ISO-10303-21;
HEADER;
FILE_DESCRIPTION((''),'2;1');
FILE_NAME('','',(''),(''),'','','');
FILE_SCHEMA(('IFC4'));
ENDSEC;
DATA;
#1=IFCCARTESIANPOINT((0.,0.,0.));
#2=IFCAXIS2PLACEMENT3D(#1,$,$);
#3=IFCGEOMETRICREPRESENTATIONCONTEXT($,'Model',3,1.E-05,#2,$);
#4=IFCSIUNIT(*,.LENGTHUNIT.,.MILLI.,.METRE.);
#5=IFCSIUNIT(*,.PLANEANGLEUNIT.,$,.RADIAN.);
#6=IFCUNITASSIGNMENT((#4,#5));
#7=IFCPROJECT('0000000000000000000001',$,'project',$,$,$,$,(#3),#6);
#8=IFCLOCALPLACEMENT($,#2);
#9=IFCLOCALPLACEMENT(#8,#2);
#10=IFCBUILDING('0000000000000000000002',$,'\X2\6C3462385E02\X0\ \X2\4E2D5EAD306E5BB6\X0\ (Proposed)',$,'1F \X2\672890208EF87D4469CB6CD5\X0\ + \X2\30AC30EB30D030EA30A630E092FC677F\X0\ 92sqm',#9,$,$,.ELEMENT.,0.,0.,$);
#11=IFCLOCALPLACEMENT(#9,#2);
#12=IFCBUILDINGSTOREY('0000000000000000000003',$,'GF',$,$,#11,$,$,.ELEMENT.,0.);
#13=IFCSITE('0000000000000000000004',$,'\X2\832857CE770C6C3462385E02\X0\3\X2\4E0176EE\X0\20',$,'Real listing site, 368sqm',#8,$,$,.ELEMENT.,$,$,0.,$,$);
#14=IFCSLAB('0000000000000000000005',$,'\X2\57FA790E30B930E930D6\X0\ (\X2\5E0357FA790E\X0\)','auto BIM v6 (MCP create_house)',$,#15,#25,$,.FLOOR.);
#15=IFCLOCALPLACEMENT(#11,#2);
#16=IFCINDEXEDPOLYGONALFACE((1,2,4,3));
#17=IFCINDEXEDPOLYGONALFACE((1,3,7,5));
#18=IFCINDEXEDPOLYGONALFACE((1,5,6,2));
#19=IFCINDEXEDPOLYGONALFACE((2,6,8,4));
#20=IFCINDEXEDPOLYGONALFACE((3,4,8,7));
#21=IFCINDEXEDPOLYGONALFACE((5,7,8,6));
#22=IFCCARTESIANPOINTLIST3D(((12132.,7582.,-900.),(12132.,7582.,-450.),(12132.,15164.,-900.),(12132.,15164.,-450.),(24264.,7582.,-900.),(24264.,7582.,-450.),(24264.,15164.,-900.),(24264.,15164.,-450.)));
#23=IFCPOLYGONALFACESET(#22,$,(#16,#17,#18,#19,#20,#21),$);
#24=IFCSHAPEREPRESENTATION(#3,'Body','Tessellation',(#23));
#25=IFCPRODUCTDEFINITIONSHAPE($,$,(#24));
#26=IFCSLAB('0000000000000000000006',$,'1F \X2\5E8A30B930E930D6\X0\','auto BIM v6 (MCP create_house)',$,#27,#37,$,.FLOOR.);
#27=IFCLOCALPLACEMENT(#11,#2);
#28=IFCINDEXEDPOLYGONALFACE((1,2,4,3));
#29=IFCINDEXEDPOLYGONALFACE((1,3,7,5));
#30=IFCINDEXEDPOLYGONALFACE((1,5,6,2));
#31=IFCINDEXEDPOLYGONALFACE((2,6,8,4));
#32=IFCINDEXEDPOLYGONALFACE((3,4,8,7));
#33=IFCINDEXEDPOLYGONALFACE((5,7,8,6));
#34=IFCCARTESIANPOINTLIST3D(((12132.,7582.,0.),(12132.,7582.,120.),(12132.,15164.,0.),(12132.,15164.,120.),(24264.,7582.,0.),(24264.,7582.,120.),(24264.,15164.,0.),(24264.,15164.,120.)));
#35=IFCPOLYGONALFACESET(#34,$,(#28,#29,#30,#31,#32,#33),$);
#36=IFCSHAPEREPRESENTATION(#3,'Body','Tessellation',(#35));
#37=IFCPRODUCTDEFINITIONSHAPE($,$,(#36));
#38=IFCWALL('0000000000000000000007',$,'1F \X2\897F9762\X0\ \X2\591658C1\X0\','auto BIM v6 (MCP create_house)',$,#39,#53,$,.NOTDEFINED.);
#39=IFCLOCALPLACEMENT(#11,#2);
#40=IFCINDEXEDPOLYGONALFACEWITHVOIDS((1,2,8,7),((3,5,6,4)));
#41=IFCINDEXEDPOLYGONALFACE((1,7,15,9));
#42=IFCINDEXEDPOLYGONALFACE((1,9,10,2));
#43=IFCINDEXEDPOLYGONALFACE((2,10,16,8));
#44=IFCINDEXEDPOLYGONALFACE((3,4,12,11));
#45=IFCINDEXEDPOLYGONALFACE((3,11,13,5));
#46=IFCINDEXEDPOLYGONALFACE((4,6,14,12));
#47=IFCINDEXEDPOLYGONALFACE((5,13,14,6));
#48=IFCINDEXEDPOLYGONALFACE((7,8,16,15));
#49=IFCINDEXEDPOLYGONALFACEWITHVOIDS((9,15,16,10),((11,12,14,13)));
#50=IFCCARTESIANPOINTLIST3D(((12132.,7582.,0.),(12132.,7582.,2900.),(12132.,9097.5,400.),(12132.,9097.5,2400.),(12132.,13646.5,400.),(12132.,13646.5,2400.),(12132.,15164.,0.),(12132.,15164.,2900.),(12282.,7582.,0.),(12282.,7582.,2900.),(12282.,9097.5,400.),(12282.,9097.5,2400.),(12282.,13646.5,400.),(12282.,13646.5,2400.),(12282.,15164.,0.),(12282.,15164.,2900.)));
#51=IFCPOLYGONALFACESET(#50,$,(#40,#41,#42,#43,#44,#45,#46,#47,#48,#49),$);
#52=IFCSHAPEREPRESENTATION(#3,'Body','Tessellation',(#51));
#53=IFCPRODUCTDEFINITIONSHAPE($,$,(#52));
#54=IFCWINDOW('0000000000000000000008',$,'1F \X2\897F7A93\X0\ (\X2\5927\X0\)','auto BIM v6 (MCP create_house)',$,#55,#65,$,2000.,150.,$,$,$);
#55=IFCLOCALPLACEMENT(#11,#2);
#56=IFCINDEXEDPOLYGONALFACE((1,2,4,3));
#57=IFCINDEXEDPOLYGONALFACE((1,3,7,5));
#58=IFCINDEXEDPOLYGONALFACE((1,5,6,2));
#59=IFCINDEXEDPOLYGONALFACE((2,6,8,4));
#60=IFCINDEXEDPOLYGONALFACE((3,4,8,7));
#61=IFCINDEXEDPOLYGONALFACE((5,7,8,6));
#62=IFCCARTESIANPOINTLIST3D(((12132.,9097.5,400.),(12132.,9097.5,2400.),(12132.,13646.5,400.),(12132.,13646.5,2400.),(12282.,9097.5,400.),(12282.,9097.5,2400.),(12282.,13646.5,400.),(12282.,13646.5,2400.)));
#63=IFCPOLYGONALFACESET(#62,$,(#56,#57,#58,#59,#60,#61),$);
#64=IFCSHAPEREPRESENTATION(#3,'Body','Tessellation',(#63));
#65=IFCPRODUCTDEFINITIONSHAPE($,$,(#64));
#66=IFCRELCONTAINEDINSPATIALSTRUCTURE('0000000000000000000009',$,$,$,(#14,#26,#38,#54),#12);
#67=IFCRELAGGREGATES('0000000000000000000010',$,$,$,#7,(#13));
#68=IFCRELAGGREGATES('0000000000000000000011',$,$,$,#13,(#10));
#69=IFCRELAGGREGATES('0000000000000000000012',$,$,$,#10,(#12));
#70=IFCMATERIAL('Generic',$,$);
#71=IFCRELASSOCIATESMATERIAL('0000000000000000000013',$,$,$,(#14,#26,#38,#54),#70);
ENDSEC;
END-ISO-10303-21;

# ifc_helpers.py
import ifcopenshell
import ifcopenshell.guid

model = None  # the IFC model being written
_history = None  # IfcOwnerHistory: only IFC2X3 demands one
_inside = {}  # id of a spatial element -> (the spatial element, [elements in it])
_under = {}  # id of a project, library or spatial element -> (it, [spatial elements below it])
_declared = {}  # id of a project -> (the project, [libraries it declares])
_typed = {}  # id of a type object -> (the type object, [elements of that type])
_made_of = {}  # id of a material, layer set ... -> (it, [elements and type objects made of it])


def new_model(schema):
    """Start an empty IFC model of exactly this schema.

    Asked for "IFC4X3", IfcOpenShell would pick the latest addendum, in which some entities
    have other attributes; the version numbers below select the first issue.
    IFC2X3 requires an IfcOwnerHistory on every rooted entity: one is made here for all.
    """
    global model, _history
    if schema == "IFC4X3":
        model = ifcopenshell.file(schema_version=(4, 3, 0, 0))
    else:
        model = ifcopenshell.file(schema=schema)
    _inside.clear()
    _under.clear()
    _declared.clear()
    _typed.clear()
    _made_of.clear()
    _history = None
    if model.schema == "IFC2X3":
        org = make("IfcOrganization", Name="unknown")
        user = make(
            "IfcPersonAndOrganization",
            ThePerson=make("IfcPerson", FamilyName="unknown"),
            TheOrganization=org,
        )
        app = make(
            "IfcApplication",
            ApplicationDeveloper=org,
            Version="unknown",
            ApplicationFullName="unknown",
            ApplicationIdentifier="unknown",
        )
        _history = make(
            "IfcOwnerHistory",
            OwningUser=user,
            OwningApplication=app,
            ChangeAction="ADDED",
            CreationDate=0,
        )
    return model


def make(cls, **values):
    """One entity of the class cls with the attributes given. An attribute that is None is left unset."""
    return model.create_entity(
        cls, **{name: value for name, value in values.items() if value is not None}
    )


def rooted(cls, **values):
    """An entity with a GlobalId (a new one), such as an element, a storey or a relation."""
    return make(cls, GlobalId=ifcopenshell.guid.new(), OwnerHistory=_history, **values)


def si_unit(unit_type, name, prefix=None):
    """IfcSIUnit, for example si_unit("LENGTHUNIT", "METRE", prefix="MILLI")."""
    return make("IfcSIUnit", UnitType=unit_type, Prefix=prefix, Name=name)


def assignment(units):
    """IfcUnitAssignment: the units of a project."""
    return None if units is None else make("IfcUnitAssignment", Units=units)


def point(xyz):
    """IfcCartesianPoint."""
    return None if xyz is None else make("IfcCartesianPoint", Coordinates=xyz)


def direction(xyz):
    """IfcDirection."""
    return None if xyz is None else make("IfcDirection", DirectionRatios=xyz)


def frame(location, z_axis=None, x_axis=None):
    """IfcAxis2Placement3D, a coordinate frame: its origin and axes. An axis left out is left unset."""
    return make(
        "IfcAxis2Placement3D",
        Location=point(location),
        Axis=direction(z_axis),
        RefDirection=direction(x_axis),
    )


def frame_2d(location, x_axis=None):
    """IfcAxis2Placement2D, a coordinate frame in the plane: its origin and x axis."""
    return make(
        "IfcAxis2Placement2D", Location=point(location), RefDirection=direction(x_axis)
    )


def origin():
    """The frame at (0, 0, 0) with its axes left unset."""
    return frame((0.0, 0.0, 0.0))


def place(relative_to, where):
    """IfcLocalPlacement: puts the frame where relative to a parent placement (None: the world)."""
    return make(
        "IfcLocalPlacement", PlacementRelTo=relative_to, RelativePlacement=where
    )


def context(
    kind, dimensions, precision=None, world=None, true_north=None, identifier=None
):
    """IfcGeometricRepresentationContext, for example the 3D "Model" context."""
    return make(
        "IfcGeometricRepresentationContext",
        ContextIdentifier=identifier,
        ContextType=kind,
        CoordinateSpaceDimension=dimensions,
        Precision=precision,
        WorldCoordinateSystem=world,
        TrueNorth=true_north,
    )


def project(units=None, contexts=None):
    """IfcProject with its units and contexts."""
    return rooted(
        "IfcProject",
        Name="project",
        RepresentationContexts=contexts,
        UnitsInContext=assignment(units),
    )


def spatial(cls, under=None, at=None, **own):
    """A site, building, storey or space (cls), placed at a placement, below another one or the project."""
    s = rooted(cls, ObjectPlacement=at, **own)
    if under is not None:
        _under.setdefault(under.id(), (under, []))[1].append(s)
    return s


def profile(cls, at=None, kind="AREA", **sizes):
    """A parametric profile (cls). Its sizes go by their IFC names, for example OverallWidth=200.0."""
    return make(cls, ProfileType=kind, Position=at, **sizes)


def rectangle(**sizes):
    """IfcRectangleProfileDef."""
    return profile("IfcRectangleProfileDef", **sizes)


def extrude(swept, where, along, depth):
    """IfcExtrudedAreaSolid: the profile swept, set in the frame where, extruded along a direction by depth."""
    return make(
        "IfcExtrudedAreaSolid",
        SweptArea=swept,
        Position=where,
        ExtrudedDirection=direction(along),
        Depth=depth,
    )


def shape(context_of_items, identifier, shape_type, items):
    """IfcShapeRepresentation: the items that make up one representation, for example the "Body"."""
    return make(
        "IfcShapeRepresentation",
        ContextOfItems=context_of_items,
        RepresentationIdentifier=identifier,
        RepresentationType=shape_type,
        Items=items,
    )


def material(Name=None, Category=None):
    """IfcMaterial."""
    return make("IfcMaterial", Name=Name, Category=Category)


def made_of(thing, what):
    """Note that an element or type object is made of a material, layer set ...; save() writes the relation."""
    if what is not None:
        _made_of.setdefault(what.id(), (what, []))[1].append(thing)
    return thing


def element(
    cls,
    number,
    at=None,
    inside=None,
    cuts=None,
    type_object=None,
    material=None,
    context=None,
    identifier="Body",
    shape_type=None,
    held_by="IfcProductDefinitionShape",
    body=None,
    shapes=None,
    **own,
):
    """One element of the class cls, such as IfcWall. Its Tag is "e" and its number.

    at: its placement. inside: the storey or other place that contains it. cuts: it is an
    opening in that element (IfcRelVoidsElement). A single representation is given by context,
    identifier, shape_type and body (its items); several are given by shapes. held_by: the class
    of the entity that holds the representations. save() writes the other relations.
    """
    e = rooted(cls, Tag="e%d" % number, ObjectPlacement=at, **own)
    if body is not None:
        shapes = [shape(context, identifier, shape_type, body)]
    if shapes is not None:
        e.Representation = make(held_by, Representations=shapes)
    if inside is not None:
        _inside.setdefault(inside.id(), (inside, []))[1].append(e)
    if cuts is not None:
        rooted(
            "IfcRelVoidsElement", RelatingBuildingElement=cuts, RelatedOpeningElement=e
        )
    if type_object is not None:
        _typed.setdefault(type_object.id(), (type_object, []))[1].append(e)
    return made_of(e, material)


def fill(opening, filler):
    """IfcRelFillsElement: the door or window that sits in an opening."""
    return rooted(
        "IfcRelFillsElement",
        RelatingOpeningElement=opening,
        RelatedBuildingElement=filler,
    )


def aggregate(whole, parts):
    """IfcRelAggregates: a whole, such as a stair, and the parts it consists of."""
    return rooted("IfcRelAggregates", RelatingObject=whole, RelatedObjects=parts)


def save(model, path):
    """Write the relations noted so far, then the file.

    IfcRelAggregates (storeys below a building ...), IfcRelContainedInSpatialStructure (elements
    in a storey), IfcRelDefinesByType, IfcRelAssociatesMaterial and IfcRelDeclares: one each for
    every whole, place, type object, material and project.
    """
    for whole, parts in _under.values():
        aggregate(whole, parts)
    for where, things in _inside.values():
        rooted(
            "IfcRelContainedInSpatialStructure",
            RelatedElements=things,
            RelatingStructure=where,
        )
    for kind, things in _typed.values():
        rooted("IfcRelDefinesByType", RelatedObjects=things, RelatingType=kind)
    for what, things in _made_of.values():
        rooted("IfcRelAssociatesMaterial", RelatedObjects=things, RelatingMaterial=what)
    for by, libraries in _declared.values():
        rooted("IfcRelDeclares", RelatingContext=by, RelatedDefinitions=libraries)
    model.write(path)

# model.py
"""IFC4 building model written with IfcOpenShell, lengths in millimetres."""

from ifc_helpers import new_model, si_unit, frame, frame_2d, origin, place, context, project, spatial, rectangle, extrude, material, element, fill, save


model = new_model("IFC4")

# Units and contexts
model_context = context("Model", 3, precision=1e-05, world=origin())
ifc_project = project(units=[si_unit("LENGTHUNIT", "METRE", prefix="MILLI"), si_unit("PLANEANGLEUNIT", "RADIAN")], contexts=[model_context])

# Site, building, storey
site_placement = place(None, origin())
site = spatial("IfcSite", under=ifc_project, at=site_placement, Name="茨城県水戸市3丁目20", ObjectType="Real listing site, 368sqm", CompositionType="ELEMENT", RefElevation=0.0)
building_placement = place(site_placement, origin())
building = spatial("IfcBuilding", under=site, at=building_placement, Name="水戸市 中庭の家 (Proposed)", ObjectType="1F 木造軸組構法 + ガルバリウム鋼板 92sqm", CompositionType="ELEMENT", ElevationOfRefHeight=0.0, ElevationOfTerrain=0.0)
storey_placement = place(building_placement, origin())
storey = spatial("IfcBuildingStorey", under=building, at=storey_placement, Name="GF", CompositionType="ELEMENT", Elevation=0.0)

# Slabs
ifc_material = material(Name="Generic")
slab_1_placement = place(storey_placement, frame((6066.0, 3791.0, -450.0)))
element("IfcSlab", 1, at=slab_1_placement, inside=storey, material=ifc_material, Name="基礎スラブ (布基礎)", Description="auto BIM v6 (MCP create_house)", PredefinedType="FLOOR", context=model_context, shape_type="SweptSolid", body=[
    extrude(rectangle(XDim=12132.0, YDim=7582.0, at=frame_2d((6066.0, 3791.0))), frame((6066.0, 3791.0, -450.0)), (0.0, 0.0, 1.0), 450.0),
])
slab_2_placement = place(storey_placement, frame((6066.0, 3791.0, 0.0)))
element("IfcSlab", 2, at=slab_2_placement, inside=storey, material=ifc_material, Name="1F 床スラブ", Description="auto BIM v6 (MCP create_house)", PredefinedType="FLOOR", context=model_context, shape_type="SweptSolid", body=[
    extrude(rectangle(XDim=12132.0, YDim=7582.0, at=frame_2d((6066.0, 3791.0))), frame((6066.0, 3791.0, 0.0)), (0.0, 0.0, 1.0), 120.0),
])

# Wall, opening, window
wall_1_placement = place(storey_placement, frame((6066.0, 3791.0, 0.0)))
wall_1 = element("IfcWall", 3, at=wall_1_placement, inside=storey, material=ifc_material, Name="1F 西面 外壁", Description="auto BIM v6 (MCP create_house)", PredefinedType="NOTDEFINED", context=model_context, shape_type="SweptSolid", body=[
    extrude(rectangle(XDim=150.0, YDim=7582.0, at=frame_2d((75.0, 3791.0))), frame((6066.0, 3791.0, 0.0)), (0.0, 0.0, 1.0), 2900.0),
])
opening_1_placement = place(storey_placement, frame((6066.0, 4549.0, 200.0)))
opening_1 = element("IfcOpeningElement", 4, at=opening_1_placement, cuts=wall_1, PredefinedType="NOTDEFINED", context=model_context, shape_type="SweptSolid", body=[
    extrude(rectangle(XDim=150.0, YDim=4549.0, at=frame_2d((75.0, 2274.0))), frame((6066.0, 4549.0, 200.0)), (0.0, 0.0, 1.0), 2000.0),
])
window_1_placement = place(storey_placement, frame((6066.0, 4549.0, 200.0)))
window_1 = element("IfcWindow", 5, at=window_1_placement, inside=storey, material=ifc_material, Name="1F 西窓 (大)", Description="auto BIM v6 (MCP create_house)", OverallHeight=2000.0, OverallWidth=150.0, context=model_context, shape_type="SweptSolid", body=[
    extrude(rectangle(XDim=150.0, YDim=4549.0, at=frame_2d((75.0, 2274.0))), frame((6066.0, 4549.0, 200.0)), (0.0, 0.0, 1.0), 2000.0),
])
fill(opening_1, window_1)

save(model, "model.ifc")
